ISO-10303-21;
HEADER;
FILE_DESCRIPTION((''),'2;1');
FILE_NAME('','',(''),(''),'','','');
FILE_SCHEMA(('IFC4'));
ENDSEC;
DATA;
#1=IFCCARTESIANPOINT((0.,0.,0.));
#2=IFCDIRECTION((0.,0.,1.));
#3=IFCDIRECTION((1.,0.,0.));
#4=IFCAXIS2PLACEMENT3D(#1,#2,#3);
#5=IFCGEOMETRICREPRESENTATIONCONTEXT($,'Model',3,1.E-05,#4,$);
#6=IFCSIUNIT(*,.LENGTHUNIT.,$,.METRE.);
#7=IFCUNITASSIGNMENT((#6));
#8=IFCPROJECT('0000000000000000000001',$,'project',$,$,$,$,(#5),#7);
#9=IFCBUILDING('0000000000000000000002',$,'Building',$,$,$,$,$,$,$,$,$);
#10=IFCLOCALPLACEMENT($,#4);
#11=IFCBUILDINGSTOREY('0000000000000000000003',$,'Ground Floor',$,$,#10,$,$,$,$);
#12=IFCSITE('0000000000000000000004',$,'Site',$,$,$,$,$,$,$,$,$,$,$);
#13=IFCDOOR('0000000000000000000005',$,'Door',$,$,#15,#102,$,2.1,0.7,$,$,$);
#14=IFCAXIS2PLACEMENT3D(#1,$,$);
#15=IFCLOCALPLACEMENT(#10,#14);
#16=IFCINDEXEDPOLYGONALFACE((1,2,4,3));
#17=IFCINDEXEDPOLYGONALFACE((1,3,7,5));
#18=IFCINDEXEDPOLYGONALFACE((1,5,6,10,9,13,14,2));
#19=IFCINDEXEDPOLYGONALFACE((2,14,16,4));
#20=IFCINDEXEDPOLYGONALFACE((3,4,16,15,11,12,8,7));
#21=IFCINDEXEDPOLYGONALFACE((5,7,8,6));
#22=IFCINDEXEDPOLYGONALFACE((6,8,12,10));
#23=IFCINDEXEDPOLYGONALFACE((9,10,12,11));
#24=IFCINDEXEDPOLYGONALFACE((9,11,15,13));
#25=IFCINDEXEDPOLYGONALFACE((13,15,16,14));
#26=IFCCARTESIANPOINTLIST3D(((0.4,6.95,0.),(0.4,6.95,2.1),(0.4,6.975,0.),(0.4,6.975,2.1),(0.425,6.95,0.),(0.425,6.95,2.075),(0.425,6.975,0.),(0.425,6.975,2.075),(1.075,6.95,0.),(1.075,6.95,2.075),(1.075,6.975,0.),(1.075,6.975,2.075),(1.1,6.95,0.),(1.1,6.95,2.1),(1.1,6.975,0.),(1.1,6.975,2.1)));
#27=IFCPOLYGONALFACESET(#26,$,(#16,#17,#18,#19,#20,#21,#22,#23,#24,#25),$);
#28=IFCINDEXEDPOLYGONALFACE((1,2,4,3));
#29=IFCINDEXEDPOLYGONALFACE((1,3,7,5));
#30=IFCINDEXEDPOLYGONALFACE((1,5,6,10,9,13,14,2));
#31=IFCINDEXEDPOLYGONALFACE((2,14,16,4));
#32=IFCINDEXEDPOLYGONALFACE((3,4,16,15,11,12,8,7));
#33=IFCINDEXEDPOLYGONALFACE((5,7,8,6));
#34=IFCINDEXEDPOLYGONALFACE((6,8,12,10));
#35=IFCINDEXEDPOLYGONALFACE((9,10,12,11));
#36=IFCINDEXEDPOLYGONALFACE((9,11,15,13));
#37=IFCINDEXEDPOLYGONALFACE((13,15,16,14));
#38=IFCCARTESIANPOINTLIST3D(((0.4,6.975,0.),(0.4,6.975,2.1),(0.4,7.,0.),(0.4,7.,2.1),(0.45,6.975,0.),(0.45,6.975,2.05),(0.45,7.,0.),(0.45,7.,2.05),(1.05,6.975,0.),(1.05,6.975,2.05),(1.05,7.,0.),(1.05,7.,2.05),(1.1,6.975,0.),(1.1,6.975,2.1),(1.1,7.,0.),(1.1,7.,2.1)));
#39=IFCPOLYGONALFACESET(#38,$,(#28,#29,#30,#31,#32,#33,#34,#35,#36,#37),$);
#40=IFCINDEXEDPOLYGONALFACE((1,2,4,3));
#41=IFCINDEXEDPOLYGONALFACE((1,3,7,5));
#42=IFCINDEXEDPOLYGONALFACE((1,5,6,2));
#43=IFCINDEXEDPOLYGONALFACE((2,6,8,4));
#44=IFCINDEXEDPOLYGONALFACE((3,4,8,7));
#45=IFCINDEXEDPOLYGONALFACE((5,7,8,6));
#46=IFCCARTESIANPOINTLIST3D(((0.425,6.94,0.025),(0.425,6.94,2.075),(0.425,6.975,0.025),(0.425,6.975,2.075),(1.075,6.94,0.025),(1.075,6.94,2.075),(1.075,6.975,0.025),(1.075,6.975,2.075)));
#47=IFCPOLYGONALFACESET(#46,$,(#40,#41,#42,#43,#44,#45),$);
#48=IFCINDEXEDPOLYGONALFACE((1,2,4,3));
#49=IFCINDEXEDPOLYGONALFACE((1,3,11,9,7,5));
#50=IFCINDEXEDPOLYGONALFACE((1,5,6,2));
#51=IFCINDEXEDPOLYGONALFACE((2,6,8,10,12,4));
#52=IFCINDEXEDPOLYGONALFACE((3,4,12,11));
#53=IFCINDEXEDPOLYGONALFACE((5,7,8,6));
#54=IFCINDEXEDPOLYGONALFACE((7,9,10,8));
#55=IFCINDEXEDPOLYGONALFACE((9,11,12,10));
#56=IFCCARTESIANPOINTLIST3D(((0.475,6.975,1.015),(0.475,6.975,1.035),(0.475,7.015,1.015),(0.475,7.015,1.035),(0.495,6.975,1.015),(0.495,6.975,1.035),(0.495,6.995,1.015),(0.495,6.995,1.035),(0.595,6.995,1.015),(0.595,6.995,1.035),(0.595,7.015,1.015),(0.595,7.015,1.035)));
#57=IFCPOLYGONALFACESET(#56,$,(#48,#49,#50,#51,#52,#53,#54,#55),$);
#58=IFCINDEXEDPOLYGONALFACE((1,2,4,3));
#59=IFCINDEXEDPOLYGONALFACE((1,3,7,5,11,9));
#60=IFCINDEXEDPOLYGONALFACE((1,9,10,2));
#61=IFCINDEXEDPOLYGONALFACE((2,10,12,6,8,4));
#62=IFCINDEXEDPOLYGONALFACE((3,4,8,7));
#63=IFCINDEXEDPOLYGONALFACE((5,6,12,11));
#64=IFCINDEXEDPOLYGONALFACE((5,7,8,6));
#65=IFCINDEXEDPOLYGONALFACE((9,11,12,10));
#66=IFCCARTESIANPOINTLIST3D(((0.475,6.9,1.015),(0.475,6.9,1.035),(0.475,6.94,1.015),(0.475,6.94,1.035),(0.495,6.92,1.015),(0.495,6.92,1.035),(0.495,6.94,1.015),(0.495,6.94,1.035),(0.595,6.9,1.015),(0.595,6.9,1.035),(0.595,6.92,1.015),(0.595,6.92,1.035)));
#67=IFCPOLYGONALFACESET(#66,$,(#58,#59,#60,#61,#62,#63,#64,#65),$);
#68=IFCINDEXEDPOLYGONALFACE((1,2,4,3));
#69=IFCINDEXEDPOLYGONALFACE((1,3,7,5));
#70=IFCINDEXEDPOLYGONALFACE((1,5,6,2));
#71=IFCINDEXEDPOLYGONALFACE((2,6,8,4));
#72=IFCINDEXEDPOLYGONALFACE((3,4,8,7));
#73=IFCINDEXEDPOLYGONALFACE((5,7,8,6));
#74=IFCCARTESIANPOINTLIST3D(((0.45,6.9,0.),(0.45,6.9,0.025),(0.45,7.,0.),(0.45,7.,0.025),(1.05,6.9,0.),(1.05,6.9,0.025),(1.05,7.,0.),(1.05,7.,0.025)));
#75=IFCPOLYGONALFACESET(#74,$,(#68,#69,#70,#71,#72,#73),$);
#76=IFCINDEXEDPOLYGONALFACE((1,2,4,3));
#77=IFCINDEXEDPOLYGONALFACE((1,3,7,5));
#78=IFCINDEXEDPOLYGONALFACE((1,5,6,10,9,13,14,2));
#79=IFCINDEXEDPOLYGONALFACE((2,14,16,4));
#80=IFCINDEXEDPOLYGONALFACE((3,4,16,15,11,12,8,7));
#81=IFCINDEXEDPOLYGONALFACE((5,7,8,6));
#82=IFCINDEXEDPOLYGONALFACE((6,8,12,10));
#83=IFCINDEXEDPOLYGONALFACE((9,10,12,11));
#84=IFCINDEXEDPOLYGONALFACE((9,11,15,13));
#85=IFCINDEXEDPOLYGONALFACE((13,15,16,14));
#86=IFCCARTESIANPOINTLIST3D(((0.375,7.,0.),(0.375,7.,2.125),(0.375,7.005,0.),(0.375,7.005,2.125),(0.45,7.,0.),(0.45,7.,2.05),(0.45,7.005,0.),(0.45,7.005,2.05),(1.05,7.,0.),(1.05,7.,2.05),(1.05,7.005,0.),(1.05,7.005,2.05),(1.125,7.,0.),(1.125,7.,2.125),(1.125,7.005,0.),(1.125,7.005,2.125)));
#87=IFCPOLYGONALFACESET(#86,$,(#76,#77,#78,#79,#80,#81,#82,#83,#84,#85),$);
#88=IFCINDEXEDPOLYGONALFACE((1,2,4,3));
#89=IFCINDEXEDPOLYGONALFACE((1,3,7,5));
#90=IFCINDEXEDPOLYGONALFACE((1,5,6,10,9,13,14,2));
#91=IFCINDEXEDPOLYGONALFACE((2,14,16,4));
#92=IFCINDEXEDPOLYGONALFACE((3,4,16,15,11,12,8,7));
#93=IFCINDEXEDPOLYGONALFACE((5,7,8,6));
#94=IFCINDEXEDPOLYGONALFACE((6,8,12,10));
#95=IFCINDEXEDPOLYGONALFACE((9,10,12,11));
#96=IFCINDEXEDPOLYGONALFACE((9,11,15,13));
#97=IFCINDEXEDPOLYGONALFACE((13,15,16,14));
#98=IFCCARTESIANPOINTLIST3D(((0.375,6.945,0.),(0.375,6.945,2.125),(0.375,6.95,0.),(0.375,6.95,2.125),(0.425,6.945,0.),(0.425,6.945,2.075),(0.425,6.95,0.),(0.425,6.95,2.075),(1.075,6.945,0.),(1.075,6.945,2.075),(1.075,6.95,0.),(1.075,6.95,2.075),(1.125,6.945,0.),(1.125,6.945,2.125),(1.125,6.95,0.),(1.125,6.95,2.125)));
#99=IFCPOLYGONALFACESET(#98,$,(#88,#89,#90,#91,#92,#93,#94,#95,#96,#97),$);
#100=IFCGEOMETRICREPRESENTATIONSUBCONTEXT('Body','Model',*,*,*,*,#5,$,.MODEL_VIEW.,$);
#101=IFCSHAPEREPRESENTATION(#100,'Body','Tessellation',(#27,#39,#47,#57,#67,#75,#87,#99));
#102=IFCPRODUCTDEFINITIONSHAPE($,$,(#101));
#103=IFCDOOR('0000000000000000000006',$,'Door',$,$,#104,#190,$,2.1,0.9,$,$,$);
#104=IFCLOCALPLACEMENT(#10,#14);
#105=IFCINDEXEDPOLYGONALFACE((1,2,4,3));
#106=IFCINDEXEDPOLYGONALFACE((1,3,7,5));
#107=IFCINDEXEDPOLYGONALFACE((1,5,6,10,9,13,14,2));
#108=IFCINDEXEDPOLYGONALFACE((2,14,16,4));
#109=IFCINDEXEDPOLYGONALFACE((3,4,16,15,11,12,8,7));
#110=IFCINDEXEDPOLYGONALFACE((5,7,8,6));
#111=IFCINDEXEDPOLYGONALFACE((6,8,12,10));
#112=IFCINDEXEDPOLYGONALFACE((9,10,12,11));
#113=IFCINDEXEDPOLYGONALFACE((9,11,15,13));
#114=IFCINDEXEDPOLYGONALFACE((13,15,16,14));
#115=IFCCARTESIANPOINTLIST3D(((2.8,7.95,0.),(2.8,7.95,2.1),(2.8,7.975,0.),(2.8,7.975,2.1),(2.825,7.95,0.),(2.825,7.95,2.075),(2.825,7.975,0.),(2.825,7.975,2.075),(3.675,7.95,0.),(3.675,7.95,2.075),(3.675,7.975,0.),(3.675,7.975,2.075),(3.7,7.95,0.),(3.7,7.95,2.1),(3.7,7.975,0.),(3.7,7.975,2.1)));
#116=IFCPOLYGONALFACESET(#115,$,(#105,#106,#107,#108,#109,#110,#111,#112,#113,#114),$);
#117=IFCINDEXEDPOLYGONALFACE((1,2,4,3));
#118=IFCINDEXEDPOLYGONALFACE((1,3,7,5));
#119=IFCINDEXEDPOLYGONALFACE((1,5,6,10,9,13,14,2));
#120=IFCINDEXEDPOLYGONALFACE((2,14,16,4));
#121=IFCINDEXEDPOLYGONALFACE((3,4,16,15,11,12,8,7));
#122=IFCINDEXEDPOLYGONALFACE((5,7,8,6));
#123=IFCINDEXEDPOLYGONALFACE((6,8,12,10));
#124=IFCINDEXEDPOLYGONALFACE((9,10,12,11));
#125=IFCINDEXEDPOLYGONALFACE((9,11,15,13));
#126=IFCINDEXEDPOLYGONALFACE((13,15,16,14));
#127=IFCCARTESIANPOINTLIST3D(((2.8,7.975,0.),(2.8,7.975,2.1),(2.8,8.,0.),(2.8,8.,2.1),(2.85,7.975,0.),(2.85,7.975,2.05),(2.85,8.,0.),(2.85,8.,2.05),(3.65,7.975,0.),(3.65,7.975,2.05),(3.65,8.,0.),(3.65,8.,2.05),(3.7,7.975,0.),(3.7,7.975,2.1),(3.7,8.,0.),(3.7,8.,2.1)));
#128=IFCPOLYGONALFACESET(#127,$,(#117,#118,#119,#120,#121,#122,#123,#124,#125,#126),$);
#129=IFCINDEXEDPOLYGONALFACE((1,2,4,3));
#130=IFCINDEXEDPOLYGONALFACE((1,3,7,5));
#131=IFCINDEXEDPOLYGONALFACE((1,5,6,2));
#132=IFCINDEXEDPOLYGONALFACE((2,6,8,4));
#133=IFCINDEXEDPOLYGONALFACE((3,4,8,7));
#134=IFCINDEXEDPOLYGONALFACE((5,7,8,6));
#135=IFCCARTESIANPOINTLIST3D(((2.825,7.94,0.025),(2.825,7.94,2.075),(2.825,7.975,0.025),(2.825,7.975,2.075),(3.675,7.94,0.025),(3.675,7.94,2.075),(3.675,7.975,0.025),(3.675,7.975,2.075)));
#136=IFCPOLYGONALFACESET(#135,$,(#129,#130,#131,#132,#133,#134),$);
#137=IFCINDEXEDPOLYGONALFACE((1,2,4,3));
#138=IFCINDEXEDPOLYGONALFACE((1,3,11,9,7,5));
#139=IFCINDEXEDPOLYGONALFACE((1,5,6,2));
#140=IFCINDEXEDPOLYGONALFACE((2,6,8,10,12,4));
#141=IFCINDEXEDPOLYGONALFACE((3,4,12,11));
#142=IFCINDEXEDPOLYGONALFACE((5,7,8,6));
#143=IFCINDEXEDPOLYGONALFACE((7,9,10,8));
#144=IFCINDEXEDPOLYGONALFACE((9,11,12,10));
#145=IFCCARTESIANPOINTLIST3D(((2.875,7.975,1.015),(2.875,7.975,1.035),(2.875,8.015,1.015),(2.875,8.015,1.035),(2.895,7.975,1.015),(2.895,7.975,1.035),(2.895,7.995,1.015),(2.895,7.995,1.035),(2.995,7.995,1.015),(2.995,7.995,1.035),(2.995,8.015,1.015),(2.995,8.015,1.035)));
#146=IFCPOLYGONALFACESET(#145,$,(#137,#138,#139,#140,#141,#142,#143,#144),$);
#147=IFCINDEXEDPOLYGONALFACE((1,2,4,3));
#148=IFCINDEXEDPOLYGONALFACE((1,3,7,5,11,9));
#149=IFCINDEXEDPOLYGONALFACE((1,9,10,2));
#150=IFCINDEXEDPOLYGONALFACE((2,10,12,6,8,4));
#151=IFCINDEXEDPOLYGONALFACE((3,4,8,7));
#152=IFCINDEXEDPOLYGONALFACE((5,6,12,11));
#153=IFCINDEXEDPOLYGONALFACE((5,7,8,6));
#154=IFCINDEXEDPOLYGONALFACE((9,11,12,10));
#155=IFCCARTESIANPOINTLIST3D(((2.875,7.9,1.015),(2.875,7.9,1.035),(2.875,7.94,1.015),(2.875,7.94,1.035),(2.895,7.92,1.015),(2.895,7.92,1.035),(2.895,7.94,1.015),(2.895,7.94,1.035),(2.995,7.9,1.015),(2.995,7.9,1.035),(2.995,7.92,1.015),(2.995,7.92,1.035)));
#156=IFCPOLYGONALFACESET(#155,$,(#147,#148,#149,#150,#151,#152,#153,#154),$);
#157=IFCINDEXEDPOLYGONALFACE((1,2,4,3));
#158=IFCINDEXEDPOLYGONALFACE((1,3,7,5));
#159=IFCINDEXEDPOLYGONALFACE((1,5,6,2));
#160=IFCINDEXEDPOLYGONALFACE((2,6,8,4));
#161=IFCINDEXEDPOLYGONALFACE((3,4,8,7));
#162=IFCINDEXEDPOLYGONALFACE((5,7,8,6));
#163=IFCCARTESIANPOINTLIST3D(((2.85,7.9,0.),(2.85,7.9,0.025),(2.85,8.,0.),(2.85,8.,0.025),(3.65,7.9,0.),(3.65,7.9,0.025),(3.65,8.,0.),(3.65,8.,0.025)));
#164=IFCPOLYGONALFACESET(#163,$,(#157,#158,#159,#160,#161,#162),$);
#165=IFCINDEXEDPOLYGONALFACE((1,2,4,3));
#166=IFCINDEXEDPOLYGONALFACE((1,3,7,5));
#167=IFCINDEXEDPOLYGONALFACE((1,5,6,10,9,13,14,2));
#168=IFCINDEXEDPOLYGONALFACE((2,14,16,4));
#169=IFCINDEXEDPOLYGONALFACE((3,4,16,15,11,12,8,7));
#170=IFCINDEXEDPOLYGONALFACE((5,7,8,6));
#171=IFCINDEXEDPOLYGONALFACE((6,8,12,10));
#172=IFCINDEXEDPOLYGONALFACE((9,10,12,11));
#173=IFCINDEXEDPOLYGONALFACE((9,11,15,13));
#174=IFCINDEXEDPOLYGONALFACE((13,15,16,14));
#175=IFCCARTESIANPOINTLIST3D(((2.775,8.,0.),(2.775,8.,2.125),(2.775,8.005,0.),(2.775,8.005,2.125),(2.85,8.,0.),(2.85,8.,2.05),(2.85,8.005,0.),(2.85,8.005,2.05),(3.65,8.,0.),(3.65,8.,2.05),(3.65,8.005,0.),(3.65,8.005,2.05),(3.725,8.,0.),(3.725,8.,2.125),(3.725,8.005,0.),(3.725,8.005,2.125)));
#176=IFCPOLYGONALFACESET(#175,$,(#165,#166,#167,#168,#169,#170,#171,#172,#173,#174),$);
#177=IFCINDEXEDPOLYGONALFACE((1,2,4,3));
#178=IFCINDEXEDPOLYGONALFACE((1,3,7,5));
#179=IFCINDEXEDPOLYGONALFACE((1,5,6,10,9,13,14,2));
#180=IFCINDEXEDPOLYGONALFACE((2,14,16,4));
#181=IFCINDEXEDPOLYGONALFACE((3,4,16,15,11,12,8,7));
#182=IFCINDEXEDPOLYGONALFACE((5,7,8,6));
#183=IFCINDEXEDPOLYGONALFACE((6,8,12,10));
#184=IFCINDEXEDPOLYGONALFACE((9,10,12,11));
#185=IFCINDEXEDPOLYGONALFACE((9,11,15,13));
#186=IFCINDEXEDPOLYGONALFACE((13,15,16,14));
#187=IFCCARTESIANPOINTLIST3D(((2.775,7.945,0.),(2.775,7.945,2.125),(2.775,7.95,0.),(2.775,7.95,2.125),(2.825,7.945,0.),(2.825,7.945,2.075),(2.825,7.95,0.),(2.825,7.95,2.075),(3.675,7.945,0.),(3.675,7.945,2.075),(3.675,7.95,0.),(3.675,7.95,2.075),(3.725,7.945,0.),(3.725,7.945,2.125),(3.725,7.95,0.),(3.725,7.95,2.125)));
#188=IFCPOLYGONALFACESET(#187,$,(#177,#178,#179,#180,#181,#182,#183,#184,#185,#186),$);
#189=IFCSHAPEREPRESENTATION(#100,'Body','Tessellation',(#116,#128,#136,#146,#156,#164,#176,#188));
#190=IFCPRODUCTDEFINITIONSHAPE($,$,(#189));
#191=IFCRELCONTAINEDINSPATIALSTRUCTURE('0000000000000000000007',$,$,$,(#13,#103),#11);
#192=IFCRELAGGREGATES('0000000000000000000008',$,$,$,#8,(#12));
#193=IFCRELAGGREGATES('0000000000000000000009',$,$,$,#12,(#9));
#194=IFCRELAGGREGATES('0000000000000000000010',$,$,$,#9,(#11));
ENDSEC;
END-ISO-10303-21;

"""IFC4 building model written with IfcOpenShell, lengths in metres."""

from ifc_helpers import new_model, si_unit, frame, origin_with_axes, place, context, subcontext, project, spatial, line, indexed_curve, outline, extrude, element, save


model = new_model("IFC4")

# Units and contexts
model_context = context("Model", 3, precision=1e-05, world=origin_with_axes())
body_context = subcontext(model_context, "Body", "Model", "MODEL_VIEW")
ifc_project = project(units=[si_unit("LENGTHUNIT", "METRE")], contexts=[model_context])

# Site, building, storey
site = spatial("IfcSite", under=ifc_project, Name="Site")
building = spatial("IfcBuilding", under=site, Name="Building")
storey_placement = place(None, origin_with_axes())
storey = spatial("IfcBuildingStorey", under=building, at=storey_placement, Name="Ground Floor")

# Doors
door_1_placement = place(storey_placement, frame((1.1, 7.0, 0.0), z_axis=(0.0, 0.0, 1.0), x_axis=(-1.0, 0.0, 0.0)))
element("IfcDoor", 1, at=door_1_placement, inside=storey, Name="Door", OverallHeight=2.1, OverallWidth=0.7, context=body_context, shape_type="SweptSolid", body=[
    extrude(outline(indexed_curve([(0.0, 0.0), (0.0, 2.1), (0.7, 2.1), (0.7, 0.0), (0.675, 0.0), (0.675, 2.075), (0.025, 2.075), (0.025, 0.0)], segments=[line(1, 2, 3, 4, 5, 6, 7, 8, 1)])), frame((0.0, 0.025, 0.0), z_axis=(0.0, -1.0, 0.0), x_axis=(1.0, 0.0, 0.0)), (0.0, 0.0, -1.0), 0.025),
    extrude(outline(indexed_curve([(0.0, 0.0), (0.0, 2.1), (0.7, 2.1), (0.7, 0.0), (0.65, 0.0), (0.65, 2.05), (0.05, 2.05), (0.05, 0.0)], segments=[line(1, 2, 3, 4, 5, 6, 7, 8, 1)])), frame((0.0, 0.0, 0.0), z_axis=(0.0, -1.0, 0.0), x_axis=(1.0, 0.0, 0.0)), (0.0, 0.0, -1.0), 0.025),
    extrude(outline(indexed_curve([(0.0, 0.0), (0.65, 0.0), (0.65, 0.035), (0.0, 0.035)], segments=[line(1, 2, 3, 4, 1)])), frame((0.025, 0.025, 0.025), z_axis=(0.0, 0.0, 1.0), x_axis=(1.0, 0.0, 0.0)), (0.0, 0.0, 1.0), 2.05),
    extrude(outline(indexed_curve([(0.0, 0.0), (0.0, -0.04), (-0.12, -0.04), (-0.12, -0.02), (-0.02, -0.02), (-0.02, 0.0)], segments=[line(1, 2, 3, 4, 5, 6, 1)])), frame((0.625, 0.025, 1.015), z_axis=(0.0, 0.0, 1.0), x_axis=(1.0, 0.0, 0.0)), (0.0, 0.0, 1.0), 0.02),
    extrude(outline(indexed_curve([(0.0, 0.0), (0.0, 0.04), (-0.12, 0.04), (-0.12, 0.02), (-0.02, 0.02), (-0.02, 0.0)], segments=[line(1, 2, 3, 4, 5, 6, 1)])), frame((0.625, 0.06, 1.015), z_axis=(0.0, 0.0, 1.0), x_axis=(1.0, 0.0, 0.0)), (0.0, 0.0, 1.0), 0.02),
    extrude(outline(indexed_curve([(0.0, 0.0), (0.6, 0.0), (0.6, 0.1), (0.0, 0.1)], segments=[line(1, 2, 3, 4, 1)])), frame((0.05, 0.0, 0.0), z_axis=(0.0, 0.0, 1.0), x_axis=(1.0, 0.0, 0.0)), (0.0, 0.0, 1.0), 0.025),
    extrude(outline(indexed_curve([(0.0, 0.0), (0.0, 2.125), (0.75, 2.125), (0.75, 0.0), (0.675, 0.0), (0.675, 2.05), (0.075, 2.05), (0.075, 0.0)], segments=[line(1, 2, 3, 4, 5, 6, 7, 8, 1)])), frame((-0.025, -0.005, 0.0), z_axis=(0.0, -1.0, 0.0), x_axis=(1.0, 0.0, 0.0)), (0.0, 0.0, -1.0), 0.005),
    extrude(outline(indexed_curve([(0.0, 0.0), (0.0, 2.125), (0.75, 2.125), (0.75, 0.0), (0.7, 0.0), (0.7, 2.075), (0.05, 2.075), (0.05, 0.0)], segments=[line(1, 2, 3, 4, 5, 6, 7, 8, 1)])), frame((-0.025, 0.05, 0.0), z_axis=(0.0, -1.0, 0.0), x_axis=(1.0, 0.0, 0.0)), (0.0, 0.0, -1.0), 0.005),
])
door_2_placement = place(storey_placement, frame((3.7, 8.0, 0.0), z_axis=(0.0, 0.0, 1.0), x_axis=(-1.0, 0.0, 0.0)))
element("IfcDoor", 2, at=door_2_placement, inside=storey, Name="Door", OverallHeight=2.1, OverallWidth=0.9, context=body_context, shape_type="SweptSolid", body=[
    extrude(outline(indexed_curve([(0.0, 0.0), (0.0, 2.1), (0.9, 2.1), (0.9, 0.0), (0.875, 0.0), (0.875, 2.075), (0.025, 2.075), (0.025, 0.0)], segments=[line(1, 2, 3, 4, 5, 6, 7, 8, 1)])), frame((0.0, 0.025, 0.0), z_axis=(0.0, -1.0, 0.0), x_axis=(1.0, 0.0, 0.0)), (0.0, 0.0, -1.0), 0.025),
    extrude(outline(indexed_curve([(0.0, 0.0), (0.0, 2.1), (0.9, 2.1), (0.9, 0.0), (0.85, 0.0), (0.85, 2.05), (0.05, 2.05), (0.05, 0.0)], segments=[line(1, 2, 3, 4, 5, 6, 7, 8, 1)])), frame((0.0, 0.0, 0.0), z_axis=(0.0, -1.0, 0.0), x_axis=(1.0, 0.0, 0.0)), (0.0, 0.0, -1.0), 0.025),
    extrude(outline(indexed_curve([(0.0, 0.0), (0.85, 0.0), (0.85, 0.035), (0.0, 0.035)], segments=[line(1, 2, 3, 4, 1)])), frame((0.025, 0.025, 0.025), z_axis=(0.0, 0.0, 1.0), x_axis=(1.0, 0.0, 0.0)), (0.0, 0.0, 1.0), 2.05),
    extrude(outline(indexed_curve([(0.0, 0.0), (0.0, -0.04), (-0.12, -0.04), (-0.12, -0.02), (-0.02, -0.02), (-0.02, 0.0)], segments=[line(1, 2, 3, 4, 5, 6, 1)])), frame((0.825, 0.025, 1.015), z_axis=(0.0, 0.0, 1.0), x_axis=(1.0, 0.0, 0.0)), (0.0, 0.0, 1.0), 0.02),
    extrude(outline(indexed_curve([(0.0, 0.0), (0.0, 0.04), (-0.12, 0.04), (-0.12, 0.02), (-0.02, 0.02), (-0.02, 0.0)], segments=[line(1, 2, 3, 4, 5, 6, 1)])), frame((0.825, 0.06, 1.015), z_axis=(0.0, 0.0, 1.0), x_axis=(1.0, 0.0, 0.0)), (0.0, 0.0, 1.0), 0.02),
    extrude(outline(indexed_curve([(0.0, 0.0), (0.8, 0.0), (0.8, 0.1), (0.0, 0.1)], segments=[line(1, 2, 3, 4, 1)])), frame((0.05, 0.0, 0.0), z_axis=(0.0, 0.0, 1.0), x_axis=(1.0, 0.0, 0.0)), (0.0, 0.0, 1.0), 0.025),
    extrude(outline(indexed_curve([(0.0, 0.0), (0.0, 2.125), (0.95, 2.125), (0.95, 0.0), (0.875, 0.0), (0.875, 2.05), (0.075, 2.05), (0.075, 0.0)], segments=[line(1, 2, 3, 4, 5, 6, 7, 8, 1)])), frame((-0.025, -0.005, 0.0), z_axis=(0.0, -1.0, 0.0), x_axis=(1.0, 0.0, 0.0)), (0.0, 0.0, -1.0), 0.005),
    extrude(outline(indexed_curve([(0.0, 0.0), (0.0, 2.125), (0.95, 2.125), (0.95, 0.0), (0.9, 0.0), (0.9, 2.075), (0.05, 2.075), (0.05, 0.0)], segments=[line(1, 2, 3, 4, 5, 6, 7, 8, 1)])), frame((-0.025, 0.05, 0.0), z_axis=(0.0, -1.0, 0.0), x_axis=(1.0, 0.0, 0.0)), (0.0, 0.0, -1.0), 0.005),
])

save(model, "model.ifc")
